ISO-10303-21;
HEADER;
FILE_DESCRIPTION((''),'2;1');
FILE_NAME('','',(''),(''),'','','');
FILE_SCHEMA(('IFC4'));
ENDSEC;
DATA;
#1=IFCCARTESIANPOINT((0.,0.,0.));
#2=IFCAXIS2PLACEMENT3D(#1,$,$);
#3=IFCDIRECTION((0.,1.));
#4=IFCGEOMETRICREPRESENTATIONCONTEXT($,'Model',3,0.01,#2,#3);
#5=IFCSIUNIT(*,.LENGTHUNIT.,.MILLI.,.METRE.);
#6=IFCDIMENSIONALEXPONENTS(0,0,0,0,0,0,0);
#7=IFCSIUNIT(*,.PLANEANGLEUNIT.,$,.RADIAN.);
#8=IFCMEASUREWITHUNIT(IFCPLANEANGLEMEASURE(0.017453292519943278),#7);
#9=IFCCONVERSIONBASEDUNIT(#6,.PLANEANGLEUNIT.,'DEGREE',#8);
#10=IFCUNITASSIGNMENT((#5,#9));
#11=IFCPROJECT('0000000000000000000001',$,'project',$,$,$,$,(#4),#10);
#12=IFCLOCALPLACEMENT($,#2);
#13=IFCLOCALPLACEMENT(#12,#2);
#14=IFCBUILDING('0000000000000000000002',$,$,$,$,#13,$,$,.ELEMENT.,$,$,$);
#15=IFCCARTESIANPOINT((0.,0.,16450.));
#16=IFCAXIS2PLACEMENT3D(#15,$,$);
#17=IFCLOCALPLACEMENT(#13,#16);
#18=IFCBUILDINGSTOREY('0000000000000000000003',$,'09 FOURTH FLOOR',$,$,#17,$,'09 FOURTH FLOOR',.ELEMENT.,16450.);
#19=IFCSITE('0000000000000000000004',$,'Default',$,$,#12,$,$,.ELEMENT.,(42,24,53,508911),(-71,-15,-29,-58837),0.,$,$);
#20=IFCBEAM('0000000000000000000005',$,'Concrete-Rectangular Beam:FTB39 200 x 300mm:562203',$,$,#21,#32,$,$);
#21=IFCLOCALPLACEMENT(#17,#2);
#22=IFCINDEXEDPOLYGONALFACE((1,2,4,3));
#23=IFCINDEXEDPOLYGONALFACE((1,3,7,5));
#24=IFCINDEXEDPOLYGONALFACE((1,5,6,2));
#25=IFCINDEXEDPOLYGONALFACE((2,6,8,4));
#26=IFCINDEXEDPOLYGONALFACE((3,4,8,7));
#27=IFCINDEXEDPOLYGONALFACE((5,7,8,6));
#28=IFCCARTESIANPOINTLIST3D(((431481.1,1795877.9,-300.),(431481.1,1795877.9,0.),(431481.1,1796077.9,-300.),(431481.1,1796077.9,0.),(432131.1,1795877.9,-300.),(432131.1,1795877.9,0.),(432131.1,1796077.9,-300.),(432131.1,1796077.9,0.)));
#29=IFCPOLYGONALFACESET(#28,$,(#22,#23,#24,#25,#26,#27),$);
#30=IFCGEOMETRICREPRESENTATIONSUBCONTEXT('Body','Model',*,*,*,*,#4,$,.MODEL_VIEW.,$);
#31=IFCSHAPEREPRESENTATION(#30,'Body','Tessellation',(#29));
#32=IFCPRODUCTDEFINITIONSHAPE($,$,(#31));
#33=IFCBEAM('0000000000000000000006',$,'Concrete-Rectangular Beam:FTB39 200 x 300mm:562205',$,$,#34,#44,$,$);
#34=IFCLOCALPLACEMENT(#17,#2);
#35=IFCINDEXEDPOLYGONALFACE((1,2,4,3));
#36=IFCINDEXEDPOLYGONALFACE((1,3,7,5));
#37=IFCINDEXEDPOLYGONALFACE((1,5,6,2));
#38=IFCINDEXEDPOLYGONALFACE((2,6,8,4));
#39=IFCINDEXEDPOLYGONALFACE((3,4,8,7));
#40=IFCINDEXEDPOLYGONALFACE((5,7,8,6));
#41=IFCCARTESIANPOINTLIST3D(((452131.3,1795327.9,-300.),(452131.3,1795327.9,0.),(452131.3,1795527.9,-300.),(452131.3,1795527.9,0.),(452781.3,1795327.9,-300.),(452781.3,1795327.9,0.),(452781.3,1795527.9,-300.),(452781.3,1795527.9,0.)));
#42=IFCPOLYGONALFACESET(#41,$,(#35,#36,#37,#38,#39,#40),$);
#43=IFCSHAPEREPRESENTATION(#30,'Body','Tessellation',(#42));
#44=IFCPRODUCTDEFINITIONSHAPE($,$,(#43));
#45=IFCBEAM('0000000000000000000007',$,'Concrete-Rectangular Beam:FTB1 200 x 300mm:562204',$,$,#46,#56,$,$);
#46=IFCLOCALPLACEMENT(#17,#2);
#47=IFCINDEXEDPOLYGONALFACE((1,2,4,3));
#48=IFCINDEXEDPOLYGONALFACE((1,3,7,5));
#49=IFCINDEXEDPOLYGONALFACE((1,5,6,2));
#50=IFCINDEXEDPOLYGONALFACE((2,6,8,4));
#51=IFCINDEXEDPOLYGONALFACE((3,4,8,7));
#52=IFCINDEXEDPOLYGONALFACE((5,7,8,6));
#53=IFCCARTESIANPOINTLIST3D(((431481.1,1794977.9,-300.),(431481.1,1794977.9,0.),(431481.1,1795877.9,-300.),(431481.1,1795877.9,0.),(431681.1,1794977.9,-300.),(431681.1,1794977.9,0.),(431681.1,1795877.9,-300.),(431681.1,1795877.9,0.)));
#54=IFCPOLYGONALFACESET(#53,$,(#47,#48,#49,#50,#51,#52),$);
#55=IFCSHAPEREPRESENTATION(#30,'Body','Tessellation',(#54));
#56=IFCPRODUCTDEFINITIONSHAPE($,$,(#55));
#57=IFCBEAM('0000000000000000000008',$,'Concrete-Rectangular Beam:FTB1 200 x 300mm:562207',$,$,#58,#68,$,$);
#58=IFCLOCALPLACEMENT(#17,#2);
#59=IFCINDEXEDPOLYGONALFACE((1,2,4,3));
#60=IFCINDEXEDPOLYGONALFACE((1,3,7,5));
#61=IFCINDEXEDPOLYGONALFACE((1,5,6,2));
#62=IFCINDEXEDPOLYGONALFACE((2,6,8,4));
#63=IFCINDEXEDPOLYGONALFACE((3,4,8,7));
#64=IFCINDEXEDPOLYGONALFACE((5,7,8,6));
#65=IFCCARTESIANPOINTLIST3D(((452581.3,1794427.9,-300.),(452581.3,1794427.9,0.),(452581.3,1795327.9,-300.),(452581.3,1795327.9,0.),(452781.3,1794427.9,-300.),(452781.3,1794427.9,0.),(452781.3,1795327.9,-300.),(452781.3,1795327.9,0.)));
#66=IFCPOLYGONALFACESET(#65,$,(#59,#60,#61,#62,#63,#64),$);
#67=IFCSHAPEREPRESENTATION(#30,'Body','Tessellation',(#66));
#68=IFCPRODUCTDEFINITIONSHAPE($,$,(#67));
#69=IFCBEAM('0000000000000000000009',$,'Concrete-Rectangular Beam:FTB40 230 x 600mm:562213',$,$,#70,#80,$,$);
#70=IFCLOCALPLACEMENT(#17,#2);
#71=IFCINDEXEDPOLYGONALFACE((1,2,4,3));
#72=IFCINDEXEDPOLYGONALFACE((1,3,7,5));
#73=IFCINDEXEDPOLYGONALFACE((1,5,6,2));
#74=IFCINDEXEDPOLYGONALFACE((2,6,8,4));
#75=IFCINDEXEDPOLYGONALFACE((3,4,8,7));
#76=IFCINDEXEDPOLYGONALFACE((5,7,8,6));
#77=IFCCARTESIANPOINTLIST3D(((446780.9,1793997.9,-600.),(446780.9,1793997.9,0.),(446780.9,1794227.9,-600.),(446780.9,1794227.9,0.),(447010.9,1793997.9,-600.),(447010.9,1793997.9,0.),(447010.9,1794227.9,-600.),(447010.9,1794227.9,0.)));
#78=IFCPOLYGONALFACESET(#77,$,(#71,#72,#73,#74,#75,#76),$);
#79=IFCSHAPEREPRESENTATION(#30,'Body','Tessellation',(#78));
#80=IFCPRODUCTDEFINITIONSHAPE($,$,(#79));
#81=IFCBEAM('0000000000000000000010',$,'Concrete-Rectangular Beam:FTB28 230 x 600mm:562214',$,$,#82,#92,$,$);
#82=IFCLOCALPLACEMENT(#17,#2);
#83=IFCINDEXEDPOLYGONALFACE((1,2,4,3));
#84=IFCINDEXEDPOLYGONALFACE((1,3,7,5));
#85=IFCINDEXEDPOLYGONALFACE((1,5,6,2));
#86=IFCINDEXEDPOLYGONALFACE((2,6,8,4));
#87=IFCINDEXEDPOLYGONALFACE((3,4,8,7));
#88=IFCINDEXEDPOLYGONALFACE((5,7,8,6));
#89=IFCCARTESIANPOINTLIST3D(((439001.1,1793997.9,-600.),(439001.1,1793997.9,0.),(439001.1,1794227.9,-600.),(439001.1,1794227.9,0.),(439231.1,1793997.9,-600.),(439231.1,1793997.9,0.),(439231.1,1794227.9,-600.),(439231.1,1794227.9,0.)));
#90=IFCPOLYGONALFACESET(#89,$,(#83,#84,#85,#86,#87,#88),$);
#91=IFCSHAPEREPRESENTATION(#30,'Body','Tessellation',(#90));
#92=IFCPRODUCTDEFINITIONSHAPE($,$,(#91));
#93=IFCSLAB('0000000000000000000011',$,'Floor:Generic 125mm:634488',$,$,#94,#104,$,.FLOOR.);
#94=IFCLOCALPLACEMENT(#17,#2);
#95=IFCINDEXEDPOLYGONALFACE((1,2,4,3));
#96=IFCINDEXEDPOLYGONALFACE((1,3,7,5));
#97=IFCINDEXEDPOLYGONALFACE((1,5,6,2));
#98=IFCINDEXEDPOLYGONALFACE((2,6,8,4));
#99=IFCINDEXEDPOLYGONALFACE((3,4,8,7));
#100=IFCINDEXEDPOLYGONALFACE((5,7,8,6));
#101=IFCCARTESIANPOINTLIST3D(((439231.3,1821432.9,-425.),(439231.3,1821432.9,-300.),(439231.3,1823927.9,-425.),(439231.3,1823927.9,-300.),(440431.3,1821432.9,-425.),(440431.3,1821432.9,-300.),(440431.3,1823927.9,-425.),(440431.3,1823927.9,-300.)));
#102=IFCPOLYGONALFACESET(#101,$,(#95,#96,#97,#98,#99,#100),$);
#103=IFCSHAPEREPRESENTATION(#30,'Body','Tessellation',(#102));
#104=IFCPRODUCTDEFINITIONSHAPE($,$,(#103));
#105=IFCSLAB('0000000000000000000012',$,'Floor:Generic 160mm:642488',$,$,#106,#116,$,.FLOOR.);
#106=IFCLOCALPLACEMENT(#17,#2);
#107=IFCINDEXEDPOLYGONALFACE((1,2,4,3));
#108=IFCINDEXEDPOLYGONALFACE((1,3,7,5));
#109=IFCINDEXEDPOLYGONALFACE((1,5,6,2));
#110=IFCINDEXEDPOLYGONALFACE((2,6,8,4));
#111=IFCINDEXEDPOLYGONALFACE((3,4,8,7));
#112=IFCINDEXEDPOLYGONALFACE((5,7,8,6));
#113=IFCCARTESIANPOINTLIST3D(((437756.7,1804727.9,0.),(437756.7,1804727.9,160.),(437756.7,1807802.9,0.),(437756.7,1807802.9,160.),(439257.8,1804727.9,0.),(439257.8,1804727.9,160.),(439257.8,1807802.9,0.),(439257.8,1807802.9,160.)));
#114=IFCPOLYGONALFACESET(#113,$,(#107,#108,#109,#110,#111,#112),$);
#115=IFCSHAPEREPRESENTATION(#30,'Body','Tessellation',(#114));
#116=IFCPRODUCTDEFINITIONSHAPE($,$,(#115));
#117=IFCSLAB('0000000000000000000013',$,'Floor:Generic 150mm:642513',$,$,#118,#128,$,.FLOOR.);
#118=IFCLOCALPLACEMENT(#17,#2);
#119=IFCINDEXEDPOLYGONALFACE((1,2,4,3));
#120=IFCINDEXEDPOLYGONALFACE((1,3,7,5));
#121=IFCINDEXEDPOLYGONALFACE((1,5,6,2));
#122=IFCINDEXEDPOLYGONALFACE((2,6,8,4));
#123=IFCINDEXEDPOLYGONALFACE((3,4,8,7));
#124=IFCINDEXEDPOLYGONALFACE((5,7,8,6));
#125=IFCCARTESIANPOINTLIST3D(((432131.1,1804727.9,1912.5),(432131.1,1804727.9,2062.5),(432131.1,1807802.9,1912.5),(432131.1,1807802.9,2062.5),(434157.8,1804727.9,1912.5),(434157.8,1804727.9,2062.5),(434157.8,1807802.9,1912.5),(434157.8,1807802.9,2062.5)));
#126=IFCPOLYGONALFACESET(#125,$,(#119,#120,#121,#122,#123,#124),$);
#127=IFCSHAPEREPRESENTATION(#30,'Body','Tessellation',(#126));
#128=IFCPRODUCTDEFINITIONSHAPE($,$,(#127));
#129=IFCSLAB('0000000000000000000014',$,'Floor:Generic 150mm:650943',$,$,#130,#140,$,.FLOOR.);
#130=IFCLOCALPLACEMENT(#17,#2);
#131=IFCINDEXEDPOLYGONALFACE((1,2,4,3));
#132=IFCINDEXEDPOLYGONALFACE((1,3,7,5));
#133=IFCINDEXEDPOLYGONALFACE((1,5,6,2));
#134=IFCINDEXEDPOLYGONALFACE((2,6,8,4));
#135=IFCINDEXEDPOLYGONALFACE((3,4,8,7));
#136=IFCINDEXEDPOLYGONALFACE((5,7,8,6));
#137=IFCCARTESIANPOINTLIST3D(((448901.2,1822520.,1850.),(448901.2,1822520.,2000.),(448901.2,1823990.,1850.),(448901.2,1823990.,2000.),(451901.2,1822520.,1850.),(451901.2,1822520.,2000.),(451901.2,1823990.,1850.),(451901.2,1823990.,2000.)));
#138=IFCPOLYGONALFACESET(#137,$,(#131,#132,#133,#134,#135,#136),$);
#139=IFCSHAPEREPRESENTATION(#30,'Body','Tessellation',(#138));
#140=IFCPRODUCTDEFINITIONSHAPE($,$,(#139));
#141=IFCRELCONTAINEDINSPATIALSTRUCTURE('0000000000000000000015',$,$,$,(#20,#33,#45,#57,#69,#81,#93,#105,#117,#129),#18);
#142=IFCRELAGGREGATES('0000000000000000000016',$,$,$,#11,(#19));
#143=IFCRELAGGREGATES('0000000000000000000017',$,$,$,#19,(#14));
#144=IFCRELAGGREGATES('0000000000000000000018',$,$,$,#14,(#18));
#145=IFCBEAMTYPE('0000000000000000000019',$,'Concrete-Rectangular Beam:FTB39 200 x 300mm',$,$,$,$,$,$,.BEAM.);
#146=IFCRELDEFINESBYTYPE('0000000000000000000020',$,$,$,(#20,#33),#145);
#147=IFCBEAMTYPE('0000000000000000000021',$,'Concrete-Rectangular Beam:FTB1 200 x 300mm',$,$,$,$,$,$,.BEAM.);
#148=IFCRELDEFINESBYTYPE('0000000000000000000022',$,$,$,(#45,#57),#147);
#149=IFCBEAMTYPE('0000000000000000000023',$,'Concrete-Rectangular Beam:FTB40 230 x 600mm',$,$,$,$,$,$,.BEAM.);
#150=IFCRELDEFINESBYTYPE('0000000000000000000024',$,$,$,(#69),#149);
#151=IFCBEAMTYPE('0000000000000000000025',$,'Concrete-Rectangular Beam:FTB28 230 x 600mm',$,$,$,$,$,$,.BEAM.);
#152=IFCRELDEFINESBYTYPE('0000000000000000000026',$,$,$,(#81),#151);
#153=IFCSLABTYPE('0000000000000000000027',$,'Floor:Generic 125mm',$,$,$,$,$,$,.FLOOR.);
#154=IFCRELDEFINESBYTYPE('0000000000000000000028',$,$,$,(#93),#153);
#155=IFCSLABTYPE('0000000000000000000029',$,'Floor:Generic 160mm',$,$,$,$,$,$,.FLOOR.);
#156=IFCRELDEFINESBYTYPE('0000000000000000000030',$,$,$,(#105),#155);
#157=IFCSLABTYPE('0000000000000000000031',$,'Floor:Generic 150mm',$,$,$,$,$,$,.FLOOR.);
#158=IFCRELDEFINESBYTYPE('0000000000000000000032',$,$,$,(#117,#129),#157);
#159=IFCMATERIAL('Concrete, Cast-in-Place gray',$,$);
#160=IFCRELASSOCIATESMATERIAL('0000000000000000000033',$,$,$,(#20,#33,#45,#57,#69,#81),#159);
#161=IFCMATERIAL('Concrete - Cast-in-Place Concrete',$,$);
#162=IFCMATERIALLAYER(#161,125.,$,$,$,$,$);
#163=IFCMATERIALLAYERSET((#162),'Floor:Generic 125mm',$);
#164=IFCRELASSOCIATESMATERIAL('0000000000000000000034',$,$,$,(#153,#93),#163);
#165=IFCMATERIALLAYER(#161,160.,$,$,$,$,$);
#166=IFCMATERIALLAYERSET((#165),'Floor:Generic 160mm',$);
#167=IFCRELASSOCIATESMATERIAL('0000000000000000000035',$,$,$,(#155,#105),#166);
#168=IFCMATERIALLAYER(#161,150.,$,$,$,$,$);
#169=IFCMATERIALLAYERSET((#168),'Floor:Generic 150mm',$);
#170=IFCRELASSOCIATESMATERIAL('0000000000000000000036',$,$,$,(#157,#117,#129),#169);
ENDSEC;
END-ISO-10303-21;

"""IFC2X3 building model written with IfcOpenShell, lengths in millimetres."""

from ifc_helpers import new_model, entity, si_unit, converted_unit, direction, frame, frame_2d, origin, place, context, subcontext, project, spatial, rectangle, extrude, material, layer, layer_set, layer_usage, type_object, element, save


model = new_model("IFC2X3")

# Units and contexts
model_context = context("Model", 3, precision=0.01, world=origin(), true_north=direction((0.0, 1.0)))
body_context = subcontext(model_context, "Body", "Model", "MODEL_VIEW")
ifc_project = project(units=[si_unit("LENGTHUNIT", "METRE", prefix="MILLI"), converted_unit("PLANEANGLEUNIT", "DEGREE", entity("IfcPlaneAngleMeasure", 0.017453292519943278), si_unit("PLANEANGLEUNIT", "RADIAN"), dimensions=[0, 0, 0, 0, 0, 0, 0])], contexts=[model_context])

# Site, building, storey
site_placement = place(None, origin())
site = spatial("IfcSite", under=ifc_project, at=site_placement, Name="Default", CompositionType="ELEMENT", RefLatitude=(42, 24, 53, 508911), RefLongitude=(-71, -15, -29, -58837), RefElevation=0.0)
building_placement = place(site_placement, origin())
building = spatial("IfcBuilding", under=site, at=building_placement, CompositionType="ELEMENT")
storey_placement = place(building_placement, frame((0.0, 0.0, 16450.0)))
storey = spatial("IfcBuildingStorey", under=building, at=storey_placement, Name="09 FOURTH FLOOR", LongName="09 FOURTH FLOOR", CompositionType="ELEMENT", Elevation=16450.0)

# Beams
ifc_material_1 = material(Name="Concrete, Cast-in-Place gray")
beam_type_1 = type_object("IfcBeamType", Name="Concrete-Rectangular Beam:FTB39 200 x 300mm", PredefinedType="BEAM")
beam_1_placement = place(storey_placement, frame((431481.1, 1796077.9, 0.0)))
element("IfcBeam", 1, at=beam_1_placement, inside=storey, type_object=beam_type_1, material=ifc_material_1, Name="Concrete-Rectangular Beam:FTB39 200 x 300mm:562203", context=body_context, shape_type="SweptSolid", body=[
    extrude(rectangle(XDim=300.0, YDim=200.0, at=frame_2d((0.0, 0.0), x_axis=(1.0, 0.0))), frame((0.0, -100.0, -150.0), z_axis=(1.0, 0.0, 0.0), x_axis=(0.0, 0.0, -1.0)), (0.0, 0.0, 1.0), 650.0),
])
beam_2_placement = place(storey_placement, frame((452781.3, 1795527.9, 0.0), z_axis=(0.0, 0.0, 1.0), x_axis=(-1.0, 0.0, 0.0)))
element("IfcBeam", 2, at=beam_2_placement, inside=storey, type_object=beam_type_1, material=ifc_material_1, Name="Concrete-Rectangular Beam:FTB39 200 x 300mm:562205", context=body_context, shape_type="SweptSolid", body=[
    extrude(rectangle(XDim=300.0, YDim=200.0, at=frame_2d((0.0, 0.0), x_axis=(1.0, 0.0))), frame((0.0, 100.0, -150.0), z_axis=(1.0, 0.0, 0.0), x_axis=(0.0, 0.0, -1.0)), (0.0, 0.0, 1.0), 650.0),
])
beam_type_2 = type_object("IfcBeamType", Name="Concrete-Rectangular Beam:FTB1 200 x 300mm", PredefinedType="BEAM")
beam_3_placement = place(storey_placement, frame((431481.1, 1794777.9, 0.0), z_axis=(0.0, 0.0, 1.0), x_axis=(0.0, 1.0, 0.0)))
element("IfcBeam", 3, at=beam_3_placement, inside=storey, type_object=beam_type_2, material=ifc_material_1, Name="Concrete-Rectangular Beam:FTB1 200 x 300mm:562204", context=body_context, shape_type="SweptSolid", body=[
    extrude(rectangle(XDim=300.0, YDim=200.0, at=frame_2d((0.0, 0.0), x_axis=(1.0, 0.0))), frame((200.0, -100.0, -150.0), z_axis=(1.0, 0.0, 0.0), x_axis=(0.0, 0.0, -1.0)), (0.0, 0.0, 1.0), 900.0),
])
beam_4_placement = place(storey_placement, frame((452781.3, 1795527.9, 0.0), z_axis=(0.0, 0.0, 1.0), x_axis=(0.0, -1.0, 0.0)))
element("IfcBeam", 4, at=beam_4_placement, inside=storey, type_object=beam_type_2, material=ifc_material_1, Name="Concrete-Rectangular Beam:FTB1 200 x 300mm:562207", context=body_context, shape_type="SweptSolid", body=[
    extrude(rectangle(XDim=300.0, YDim=200.0, at=frame_2d((0.0, 0.0), x_axis=(1.0, 0.0))), frame((200.0, -100.0, -150.0), z_axis=(1.0, 0.0, 0.0), x_axis=(0.0, 0.0, -1.0)), (0.0, 0.0, 1.0), 900.0),
])
beam_type_3 = type_object("IfcBeamType", Name="Concrete-Rectangular Beam:FTB40 230 x 600mm", PredefinedType="BEAM")
beam_5_placement = place(storey_placement, frame((446780.9, 1793997.9, 0.0), z_axis=(0.0, 0.0, 1.0), x_axis=(0.0, 1.0, 0.0)))
element("IfcBeam", 5, at=beam_5_placement, inside=storey, type_object=beam_type_3, material=ifc_material_1, Name="Concrete-Rectangular Beam:FTB40 230 x 600mm:562213", context=body_context, shape_type="SweptSolid", body=[
    extrude(rectangle(XDim=600.0, YDim=230.0, at=frame_2d((0.0, 0.0), x_axis=(1.0, 0.0))), frame((0.0, -115.0, -300.0), z_axis=(1.0, 0.0, 0.0), x_axis=(0.0, 0.0, -1.0)), (0.0, 0.0, 1.0), 230.0),
])
beam_type_4 = type_object("IfcBeamType", Name="Concrete-Rectangular Beam:FTB28 230 x 600mm", PredefinedType="BEAM")
beam_6_placement = place(storey_placement, frame((439231.1, 1794227.9, 0.0), z_axis=(0.0, 0.0, 1.0), x_axis=(0.0, -1.0, 0.0)))
element("IfcBeam", 6, at=beam_6_placement, inside=storey, type_object=beam_type_4, material=ifc_material_1, Name="Concrete-Rectangular Beam:FTB28 230 x 600mm:562214", context=body_context, shape_type="SweptSolid", body=[
    extrude(rectangle(XDim=600.0, YDim=230.0, at=frame_2d((0.0, 0.0), x_axis=(1.0, 0.0))), frame((0.0, -115.0, -300.0), z_axis=(1.0, 0.0, 0.0), x_axis=(0.0, 0.0, -1.0)), (0.0, 0.0, 1.0), 230.0),
])

# Slab
ifc_material_2 = material(Name="Concrete - Cast-in-Place Concrete")
ifc_layer_1 = layer(ifc_material_2, 125.0)
ifc_layer_set_1 = layer_set([ifc_layer_1], Name="Floor:Generic 125mm")
slab_type_1 = type_object("IfcSlabType", Name="Floor:Generic 125mm", PredefinedType="FLOOR", material=ifc_layer_set_1)
ifc_layer_usage_1 = layer_usage(ifc_layer_set_1, "AXIS3", "POSITIVE", 0.0)
slab_1_placement = place(storey_placement, origin())
element("IfcSlab", 7, at=slab_1_placement, inside=storey, type_object=slab_type_1, material=ifc_layer_usage_1, Name="Floor:Generic 125mm:634488", PredefinedType="FLOOR", context=body_context, shape_type="SweptSolid", body=[
    extrude(rectangle(XDim=2495.0, YDim=1200.0, at=frame_2d((0.0, 0.0), x_axis=(1.0, 0.0))), frame((439831.3, 1822680.4, -300.0), z_axis=(0.0, 0.0, -1.0), x_axis=(0.0, 1.0, 0.0)), (0.0, 0.0, 1.0), 125.0),
])

# Slab
ifc_layer_2 = layer(ifc_material_2, 160.0)
ifc_layer_set_2 = layer_set([ifc_layer_2], Name="Floor:Generic 160mm")
ifc_layer_usage_2 = layer_usage(ifc_layer_set_2, "AXIS3", "POSITIVE", 0.0)
slab_type_2 = type_object("IfcSlabType", Name="Floor:Generic 160mm", PredefinedType="FLOOR", material=ifc_layer_set_2)
slab_2_placement = place(storey_placement, origin())
element("IfcSlab", 8, at=slab_2_placement, inside=storey, type_object=slab_type_2, material=ifc_layer_usage_2, Name="Floor:Generic 160mm:642488", PredefinedType="FLOOR", context=body_context, shape_type="SweptSolid", body=[
    extrude(rectangle(XDim=3075.0, YDim=1501.1, at=frame_2d((0.0, 0.0), x_axis=(1.0, 0.0))), frame((438507.2, 1806265.4, 160.0), z_axis=(0.0, 0.0, -1.0), x_axis=(0.0, 1.0, 0.0)), (0.0, 0.0, 1.0), 160.0),
])

# Slabs
ifc_layer_3 = layer(ifc_material_2, 150.0)
ifc_layer_set_3 = layer_set([ifc_layer_3], Name="Floor:Generic 150mm")
ifc_layer_usage_3 = layer_usage(ifc_layer_set_3, "AXIS3", "POSITIVE", 0.0)
slab_type_3 = type_object("IfcSlabType", Name="Floor:Generic 150mm", PredefinedType="FLOOR", material=ifc_layer_set_3)
slab_3_placement = place(storey_placement, origin())
element("IfcSlab", 9, at=slab_3_placement, inside=storey, type_object=slab_type_3, material=ifc_layer_usage_3, Name="Floor:Generic 150mm:642513", PredefinedType="FLOOR", context=body_context, shape_type="SweptSolid", body=[
    extrude(rectangle(XDim=3075.0, YDim=2026.7, at=frame_2d((0.0, 0.0), x_axis=(1.0, 0.0))), frame((433144.4, 1806265.4, 2062.5), z_axis=(0.0, 0.0, -1.0), x_axis=(0.0, 1.0, 0.0)), (0.0, 0.0, 1.0), 150.0),
])
ifc_layer_usage_4 = layer_usage(ifc_layer_set_3, "AXIS3", "POSITIVE", 0.0)
slab_4_placement = place(storey_placement, origin())
element("IfcSlab", 10, at=slab_4_placement, inside=storey, type_object=slab_type_3, material=ifc_layer_usage_4, Name="Floor:Generic 150mm:650943", PredefinedType="FLOOR", context=body_context, shape_type="SweptSolid", body=[
    extrude(rectangle(XDim=1470.0, YDim=3000.0, at=frame_2d((0.0, 0.0), x_axis=(1.0, 0.0))), frame((450401.2, 1823255.0, 2000.0), z_axis=(0.0, 0.0, -1.0), x_axis=(0.0, 1.0, 0.0)), (0.0, 0.0, 1.0), 150.0),
])

save(model, "model.ifc")
